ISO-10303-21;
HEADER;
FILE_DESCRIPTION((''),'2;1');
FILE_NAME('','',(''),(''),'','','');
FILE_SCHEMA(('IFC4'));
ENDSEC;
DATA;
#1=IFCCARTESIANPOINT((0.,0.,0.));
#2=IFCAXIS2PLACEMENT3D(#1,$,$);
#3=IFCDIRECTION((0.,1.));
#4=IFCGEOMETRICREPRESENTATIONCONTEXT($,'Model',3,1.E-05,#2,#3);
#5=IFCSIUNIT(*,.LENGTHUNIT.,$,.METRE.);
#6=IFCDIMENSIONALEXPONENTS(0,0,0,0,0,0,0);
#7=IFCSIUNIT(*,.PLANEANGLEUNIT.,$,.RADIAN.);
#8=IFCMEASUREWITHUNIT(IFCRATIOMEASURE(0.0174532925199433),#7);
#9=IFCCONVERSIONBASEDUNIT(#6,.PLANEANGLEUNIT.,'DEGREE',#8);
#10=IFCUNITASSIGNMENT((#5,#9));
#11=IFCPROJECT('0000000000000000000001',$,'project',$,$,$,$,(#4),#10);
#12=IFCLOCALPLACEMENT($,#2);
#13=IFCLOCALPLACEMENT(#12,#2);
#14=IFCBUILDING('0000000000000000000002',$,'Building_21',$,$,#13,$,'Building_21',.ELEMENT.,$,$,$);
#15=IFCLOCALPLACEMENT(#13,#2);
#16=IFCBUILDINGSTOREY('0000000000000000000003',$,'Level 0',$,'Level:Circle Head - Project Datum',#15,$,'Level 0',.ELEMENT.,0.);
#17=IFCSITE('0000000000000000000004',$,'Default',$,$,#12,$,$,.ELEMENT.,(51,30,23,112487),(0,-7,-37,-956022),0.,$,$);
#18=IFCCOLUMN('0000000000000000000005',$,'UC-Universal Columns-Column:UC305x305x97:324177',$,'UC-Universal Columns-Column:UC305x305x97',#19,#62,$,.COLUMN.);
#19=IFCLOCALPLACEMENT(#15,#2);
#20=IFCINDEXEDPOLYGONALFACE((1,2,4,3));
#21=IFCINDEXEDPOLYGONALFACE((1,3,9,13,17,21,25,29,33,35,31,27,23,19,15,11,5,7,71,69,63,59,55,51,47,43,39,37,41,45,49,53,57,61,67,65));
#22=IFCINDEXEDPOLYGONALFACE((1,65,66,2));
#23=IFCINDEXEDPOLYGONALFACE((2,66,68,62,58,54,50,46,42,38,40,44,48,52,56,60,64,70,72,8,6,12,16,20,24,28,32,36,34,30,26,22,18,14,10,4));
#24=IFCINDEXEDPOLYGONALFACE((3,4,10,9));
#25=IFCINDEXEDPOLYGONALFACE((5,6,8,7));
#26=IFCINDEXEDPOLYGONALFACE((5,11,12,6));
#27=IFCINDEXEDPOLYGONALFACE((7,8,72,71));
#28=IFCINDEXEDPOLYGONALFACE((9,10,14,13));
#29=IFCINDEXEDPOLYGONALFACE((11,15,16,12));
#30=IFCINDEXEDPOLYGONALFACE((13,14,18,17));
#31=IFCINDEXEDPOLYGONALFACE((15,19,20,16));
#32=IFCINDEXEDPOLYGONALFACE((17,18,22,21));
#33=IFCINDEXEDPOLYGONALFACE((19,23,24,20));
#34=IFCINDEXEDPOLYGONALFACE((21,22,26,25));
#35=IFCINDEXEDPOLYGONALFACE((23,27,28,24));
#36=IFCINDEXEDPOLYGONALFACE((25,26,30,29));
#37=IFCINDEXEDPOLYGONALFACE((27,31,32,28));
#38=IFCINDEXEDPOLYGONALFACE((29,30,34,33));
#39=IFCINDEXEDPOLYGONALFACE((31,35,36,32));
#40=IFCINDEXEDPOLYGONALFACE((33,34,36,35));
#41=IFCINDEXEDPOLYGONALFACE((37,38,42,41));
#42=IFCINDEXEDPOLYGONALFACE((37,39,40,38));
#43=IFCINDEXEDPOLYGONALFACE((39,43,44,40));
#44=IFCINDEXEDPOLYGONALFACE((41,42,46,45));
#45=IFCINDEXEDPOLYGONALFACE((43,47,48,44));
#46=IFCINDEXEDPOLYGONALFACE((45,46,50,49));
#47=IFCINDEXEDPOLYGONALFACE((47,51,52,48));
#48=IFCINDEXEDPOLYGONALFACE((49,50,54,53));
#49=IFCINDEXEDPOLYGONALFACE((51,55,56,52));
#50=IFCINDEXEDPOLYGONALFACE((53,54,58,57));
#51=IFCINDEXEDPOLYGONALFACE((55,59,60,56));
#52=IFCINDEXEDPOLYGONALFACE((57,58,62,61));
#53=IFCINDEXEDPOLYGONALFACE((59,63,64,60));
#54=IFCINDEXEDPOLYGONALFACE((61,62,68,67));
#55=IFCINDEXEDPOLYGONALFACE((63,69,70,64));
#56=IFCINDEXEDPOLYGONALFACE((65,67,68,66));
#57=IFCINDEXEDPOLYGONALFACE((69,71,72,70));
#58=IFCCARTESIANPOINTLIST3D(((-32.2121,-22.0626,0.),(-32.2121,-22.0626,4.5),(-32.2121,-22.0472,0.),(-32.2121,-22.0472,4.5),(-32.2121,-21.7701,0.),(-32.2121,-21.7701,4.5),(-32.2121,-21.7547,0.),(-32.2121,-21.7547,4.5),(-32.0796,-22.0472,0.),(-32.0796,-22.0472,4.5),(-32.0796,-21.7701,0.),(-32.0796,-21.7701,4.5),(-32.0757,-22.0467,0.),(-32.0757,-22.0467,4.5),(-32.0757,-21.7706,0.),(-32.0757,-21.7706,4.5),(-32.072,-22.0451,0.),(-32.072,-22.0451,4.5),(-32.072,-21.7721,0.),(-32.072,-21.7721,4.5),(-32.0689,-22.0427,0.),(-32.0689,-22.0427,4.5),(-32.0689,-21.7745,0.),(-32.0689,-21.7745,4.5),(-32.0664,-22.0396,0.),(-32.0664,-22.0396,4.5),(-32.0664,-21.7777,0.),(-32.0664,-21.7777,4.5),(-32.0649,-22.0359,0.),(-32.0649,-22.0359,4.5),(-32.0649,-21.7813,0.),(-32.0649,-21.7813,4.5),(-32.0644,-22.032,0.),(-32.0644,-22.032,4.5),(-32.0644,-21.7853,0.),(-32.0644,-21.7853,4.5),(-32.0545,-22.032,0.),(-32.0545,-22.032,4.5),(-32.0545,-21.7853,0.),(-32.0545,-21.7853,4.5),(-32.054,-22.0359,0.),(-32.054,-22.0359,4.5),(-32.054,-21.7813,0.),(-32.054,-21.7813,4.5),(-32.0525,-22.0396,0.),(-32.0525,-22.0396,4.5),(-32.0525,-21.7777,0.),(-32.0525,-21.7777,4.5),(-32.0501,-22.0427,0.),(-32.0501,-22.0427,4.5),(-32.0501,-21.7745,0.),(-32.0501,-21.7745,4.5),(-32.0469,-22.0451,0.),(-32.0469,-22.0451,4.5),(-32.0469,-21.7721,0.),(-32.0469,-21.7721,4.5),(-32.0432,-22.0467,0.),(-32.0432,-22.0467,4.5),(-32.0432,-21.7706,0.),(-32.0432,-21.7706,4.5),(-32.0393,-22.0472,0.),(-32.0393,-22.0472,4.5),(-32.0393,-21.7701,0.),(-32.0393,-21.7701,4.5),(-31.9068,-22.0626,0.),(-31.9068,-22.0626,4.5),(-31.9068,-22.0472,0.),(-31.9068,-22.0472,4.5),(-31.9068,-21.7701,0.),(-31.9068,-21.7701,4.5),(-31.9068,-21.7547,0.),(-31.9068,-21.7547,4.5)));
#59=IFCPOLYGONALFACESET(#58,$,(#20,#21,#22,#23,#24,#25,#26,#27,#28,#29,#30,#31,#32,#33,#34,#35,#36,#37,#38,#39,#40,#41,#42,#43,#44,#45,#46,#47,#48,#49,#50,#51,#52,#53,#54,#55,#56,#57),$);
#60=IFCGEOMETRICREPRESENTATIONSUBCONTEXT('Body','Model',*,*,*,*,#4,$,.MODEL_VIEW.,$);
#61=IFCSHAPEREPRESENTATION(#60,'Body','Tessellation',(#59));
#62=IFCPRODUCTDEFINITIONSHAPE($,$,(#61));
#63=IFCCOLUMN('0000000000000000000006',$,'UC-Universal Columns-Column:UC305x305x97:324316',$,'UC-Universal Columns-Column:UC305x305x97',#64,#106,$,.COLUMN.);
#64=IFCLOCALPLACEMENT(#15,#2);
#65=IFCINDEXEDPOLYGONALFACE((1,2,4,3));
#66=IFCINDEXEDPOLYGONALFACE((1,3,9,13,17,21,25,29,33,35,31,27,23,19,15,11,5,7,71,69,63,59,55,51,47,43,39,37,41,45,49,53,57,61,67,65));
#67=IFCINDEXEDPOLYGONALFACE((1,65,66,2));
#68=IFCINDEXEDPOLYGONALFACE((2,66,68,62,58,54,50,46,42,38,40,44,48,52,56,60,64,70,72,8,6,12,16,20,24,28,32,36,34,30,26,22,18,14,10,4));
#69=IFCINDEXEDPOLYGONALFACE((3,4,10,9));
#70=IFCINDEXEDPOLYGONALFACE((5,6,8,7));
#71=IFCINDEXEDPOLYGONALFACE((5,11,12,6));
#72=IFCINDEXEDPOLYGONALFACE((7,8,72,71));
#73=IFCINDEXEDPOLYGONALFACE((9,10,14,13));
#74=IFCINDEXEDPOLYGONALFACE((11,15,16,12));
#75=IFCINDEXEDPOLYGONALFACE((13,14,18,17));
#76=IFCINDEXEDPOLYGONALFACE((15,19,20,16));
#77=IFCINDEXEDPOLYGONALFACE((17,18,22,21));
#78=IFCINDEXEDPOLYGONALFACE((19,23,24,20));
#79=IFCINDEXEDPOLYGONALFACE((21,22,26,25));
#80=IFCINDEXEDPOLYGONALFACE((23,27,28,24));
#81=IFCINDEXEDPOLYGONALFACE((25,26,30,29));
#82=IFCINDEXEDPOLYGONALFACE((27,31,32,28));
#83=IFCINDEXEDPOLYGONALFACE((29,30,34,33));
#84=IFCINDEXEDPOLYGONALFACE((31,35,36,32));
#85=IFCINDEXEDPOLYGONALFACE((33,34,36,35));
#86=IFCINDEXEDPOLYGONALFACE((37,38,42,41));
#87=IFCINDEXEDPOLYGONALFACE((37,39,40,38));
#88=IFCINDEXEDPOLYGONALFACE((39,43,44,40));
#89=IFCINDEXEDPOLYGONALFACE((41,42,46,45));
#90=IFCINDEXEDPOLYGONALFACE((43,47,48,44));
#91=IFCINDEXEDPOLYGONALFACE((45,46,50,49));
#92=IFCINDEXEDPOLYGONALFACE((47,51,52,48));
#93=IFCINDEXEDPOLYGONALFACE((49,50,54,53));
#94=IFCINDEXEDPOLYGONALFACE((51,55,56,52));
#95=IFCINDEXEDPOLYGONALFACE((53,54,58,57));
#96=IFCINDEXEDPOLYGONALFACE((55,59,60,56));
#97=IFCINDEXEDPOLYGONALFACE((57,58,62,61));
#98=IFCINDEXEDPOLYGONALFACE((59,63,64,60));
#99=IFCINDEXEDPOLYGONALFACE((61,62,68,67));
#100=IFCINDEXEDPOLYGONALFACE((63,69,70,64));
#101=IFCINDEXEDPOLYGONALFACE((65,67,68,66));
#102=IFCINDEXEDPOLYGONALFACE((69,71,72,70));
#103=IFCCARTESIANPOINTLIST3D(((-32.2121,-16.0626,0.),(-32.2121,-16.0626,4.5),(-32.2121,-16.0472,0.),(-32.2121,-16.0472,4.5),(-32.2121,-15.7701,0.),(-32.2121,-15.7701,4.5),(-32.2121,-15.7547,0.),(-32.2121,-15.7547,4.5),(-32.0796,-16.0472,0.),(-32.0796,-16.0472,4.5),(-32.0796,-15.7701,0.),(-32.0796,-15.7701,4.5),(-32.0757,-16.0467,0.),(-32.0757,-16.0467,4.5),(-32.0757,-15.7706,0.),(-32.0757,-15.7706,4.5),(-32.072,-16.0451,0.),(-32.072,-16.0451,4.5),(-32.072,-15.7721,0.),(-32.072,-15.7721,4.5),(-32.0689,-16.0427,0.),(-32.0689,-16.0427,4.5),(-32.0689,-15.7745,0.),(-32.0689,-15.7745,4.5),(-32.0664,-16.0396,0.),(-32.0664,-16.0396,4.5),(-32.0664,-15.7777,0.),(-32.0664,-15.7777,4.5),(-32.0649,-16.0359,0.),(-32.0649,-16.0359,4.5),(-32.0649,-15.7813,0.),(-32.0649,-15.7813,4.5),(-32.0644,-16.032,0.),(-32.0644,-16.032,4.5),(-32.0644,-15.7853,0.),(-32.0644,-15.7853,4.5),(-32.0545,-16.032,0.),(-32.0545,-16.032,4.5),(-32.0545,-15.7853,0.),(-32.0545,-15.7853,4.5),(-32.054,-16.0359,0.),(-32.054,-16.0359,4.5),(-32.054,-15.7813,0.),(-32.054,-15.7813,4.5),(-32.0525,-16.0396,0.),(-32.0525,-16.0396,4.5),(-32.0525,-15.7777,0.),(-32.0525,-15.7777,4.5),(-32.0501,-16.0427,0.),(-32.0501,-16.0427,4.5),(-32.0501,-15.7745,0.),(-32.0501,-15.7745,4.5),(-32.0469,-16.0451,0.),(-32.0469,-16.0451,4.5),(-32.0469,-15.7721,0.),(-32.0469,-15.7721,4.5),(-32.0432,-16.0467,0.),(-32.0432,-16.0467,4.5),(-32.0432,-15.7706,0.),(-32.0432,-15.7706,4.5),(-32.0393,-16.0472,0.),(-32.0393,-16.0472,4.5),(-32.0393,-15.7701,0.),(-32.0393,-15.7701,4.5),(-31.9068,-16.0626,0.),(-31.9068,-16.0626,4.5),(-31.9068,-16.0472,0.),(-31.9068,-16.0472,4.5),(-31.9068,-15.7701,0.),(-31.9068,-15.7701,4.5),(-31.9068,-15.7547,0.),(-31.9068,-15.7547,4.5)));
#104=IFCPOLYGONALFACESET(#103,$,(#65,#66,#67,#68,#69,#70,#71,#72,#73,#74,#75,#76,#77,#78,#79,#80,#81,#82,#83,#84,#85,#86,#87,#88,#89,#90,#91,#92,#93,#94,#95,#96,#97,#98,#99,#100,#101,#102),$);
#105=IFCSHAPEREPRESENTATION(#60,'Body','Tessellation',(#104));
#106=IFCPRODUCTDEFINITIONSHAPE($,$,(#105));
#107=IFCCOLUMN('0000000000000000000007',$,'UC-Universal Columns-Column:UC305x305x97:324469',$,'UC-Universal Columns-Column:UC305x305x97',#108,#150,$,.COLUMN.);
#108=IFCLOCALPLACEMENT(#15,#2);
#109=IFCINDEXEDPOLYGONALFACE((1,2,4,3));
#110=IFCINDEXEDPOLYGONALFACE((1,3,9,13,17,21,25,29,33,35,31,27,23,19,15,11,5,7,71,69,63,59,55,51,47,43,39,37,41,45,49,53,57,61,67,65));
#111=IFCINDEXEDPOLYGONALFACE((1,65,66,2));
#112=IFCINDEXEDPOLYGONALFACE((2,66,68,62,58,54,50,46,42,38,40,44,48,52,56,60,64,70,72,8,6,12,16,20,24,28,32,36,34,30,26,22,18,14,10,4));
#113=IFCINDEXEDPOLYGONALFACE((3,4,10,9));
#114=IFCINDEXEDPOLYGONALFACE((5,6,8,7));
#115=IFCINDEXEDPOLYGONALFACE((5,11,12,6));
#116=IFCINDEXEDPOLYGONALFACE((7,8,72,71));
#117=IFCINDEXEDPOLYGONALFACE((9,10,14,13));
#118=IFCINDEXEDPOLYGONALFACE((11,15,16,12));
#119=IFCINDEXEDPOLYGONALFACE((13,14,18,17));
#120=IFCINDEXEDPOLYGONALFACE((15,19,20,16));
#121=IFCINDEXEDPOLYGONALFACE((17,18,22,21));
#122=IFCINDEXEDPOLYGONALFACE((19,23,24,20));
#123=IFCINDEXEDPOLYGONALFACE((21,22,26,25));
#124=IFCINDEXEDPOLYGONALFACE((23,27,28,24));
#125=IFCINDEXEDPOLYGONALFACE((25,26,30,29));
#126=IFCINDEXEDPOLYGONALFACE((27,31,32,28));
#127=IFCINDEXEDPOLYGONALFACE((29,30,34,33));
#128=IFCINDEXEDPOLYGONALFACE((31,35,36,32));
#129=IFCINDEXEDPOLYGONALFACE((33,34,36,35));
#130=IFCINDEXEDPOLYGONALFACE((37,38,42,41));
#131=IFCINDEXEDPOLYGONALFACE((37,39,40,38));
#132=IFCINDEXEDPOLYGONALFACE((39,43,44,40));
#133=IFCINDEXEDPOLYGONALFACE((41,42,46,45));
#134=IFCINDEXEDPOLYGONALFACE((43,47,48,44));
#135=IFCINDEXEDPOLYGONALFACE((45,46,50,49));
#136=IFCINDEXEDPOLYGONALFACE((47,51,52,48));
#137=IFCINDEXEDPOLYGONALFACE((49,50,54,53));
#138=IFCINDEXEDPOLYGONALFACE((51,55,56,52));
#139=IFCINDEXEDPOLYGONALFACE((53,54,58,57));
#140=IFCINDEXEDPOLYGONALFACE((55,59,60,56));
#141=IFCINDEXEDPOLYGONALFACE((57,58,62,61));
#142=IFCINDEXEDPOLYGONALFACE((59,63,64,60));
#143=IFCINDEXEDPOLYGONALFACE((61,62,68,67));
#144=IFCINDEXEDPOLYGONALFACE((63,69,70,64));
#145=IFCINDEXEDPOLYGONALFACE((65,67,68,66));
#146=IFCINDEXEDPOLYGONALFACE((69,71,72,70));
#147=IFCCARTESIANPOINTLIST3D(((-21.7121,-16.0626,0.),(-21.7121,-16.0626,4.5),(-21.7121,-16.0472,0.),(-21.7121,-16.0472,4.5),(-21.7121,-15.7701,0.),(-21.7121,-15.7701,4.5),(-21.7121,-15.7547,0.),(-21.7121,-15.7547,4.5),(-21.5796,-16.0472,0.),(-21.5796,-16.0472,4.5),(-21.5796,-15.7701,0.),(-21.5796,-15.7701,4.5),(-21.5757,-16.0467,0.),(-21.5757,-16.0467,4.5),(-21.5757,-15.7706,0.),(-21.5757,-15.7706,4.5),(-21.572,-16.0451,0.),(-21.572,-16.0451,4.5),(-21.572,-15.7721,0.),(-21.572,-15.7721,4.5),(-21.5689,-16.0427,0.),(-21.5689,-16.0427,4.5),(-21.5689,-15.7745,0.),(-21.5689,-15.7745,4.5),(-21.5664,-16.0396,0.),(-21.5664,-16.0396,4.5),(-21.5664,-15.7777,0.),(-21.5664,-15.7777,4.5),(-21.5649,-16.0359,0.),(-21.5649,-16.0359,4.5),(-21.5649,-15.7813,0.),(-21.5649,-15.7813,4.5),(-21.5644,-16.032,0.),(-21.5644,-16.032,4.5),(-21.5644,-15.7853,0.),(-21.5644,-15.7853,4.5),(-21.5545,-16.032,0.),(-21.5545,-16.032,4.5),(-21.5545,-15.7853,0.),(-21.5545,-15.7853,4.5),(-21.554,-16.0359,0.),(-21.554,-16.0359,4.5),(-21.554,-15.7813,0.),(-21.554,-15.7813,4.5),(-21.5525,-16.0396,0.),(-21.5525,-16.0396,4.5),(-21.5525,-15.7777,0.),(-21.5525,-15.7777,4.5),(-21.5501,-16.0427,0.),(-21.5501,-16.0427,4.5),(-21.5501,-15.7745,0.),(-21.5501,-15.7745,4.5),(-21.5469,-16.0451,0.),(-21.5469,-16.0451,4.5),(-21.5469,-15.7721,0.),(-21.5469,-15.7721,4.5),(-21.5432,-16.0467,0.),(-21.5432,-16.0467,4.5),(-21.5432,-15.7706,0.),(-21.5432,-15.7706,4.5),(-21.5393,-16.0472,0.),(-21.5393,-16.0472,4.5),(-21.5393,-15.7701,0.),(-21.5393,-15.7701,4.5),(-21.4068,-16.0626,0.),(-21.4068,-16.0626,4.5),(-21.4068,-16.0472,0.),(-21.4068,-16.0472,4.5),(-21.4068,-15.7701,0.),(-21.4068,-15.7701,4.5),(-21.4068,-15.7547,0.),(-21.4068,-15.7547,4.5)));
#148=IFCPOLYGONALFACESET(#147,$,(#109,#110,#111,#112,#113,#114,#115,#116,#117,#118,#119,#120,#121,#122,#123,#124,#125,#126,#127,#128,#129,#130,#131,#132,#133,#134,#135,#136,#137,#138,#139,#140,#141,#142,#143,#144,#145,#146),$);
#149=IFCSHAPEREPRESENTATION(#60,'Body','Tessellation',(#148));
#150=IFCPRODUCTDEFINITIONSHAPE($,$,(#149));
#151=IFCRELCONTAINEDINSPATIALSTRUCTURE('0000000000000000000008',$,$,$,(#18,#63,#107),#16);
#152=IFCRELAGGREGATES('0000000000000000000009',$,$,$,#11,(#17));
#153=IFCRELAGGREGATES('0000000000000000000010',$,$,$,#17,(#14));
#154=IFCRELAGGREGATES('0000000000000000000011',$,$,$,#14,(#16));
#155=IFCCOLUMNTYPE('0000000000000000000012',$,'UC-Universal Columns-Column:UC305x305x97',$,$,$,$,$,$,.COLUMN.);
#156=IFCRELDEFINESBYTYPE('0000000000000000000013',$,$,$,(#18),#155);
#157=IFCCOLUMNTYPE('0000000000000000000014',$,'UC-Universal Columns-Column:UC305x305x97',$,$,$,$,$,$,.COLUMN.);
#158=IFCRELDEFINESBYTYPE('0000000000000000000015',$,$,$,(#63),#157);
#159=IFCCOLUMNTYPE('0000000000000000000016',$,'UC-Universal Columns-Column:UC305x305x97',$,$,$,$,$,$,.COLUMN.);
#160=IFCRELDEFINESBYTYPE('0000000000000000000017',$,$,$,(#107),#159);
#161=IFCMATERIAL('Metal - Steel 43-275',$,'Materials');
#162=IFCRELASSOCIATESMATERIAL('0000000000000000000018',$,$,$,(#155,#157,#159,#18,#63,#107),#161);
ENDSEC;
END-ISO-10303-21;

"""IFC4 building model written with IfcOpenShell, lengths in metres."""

from ifc_helpers import new_model, entity, si_unit, converted_unit, direction, frame, frame_2d, origin, place, context, subcontext, project, spatial, polyline, circle_curve, parameter, trimmed, segment, composite_curve, i_section, outline, extrude, source, transform, mapped, material, material_profile, profile_set, profile_usage, type_object, type_shapes, element, save


model = new_model("IFC4")

# Units and contexts
model_context = context("Model", 3, precision=1e-05, world=origin(), true_north=direction((0.0, 1.0)))
body_context = subcontext(model_context, "Body", "Model", "MODEL_VIEW")
ifc_project = project(units=[si_unit("LENGTHUNIT", "METRE"), converted_unit("PLANEANGLEUNIT", "DEGREE", entity("IfcRatioMeasure", 0.0174532925199433), si_unit("PLANEANGLEUNIT", "RADIAN"), dimensions=[0, 0, 0, 0, 0, 0, 0])], contexts=[model_context])

# Site, building, storey
site_placement = place(None, origin())
site = spatial("IfcSite", under=ifc_project, at=site_placement, Name="Default", CompositionType="ELEMENT", RefLatitude=(51, 30, 23, 112487), RefLongitude=(0, -7, -37, -956022), RefElevation=0.0)
building_placement = place(site_placement, origin())
building = spatial("IfcBuilding", under=site, at=building_placement, Name="Building_21", LongName="Building_21", CompositionType="ELEMENT")
storey_placement = place(building_placement, origin())
storey = spatial("IfcBuildingStorey", under=building, at=storey_placement, Name="Level 0", ObjectType="Level:Circle Head - Project Datum", LongName="Level 0", CompositionType="ELEMENT", Elevation=0.0)

# Columns
ifc_material_1 = material(Name="Metal - Steel 43-275", Category="Materials")
ifc_material_profile_1 = material_profile(ifc_material_1, outline(composite_curve([segment(polyline([(-0.1527, 0.154, 0.0), (0.1527, 0.154, 0.0)]), True, "CONTINUOUS"), segment(polyline([(0.1527, 0.154, 0.0), (0.1527, 0.1386, 0.0)]), True, "CONTINUOUS"), segment(polyline([(0.1527, 0.1386, 0.0), (0.0201, 0.1386, 0.0)]), True, "CONTINUOUS"), segment(trimmed(circle_curve(frame((0.0201, 0.1234, 0.0)), 0.0152), [parameter(90.0)], [parameter(180.0)], True, "PARAMETER"), True, "CONTINUOUS"), segment(polyline([(0.0049, 0.1234, 0.0), (0.0049, -0.1234, 0.0)]), True, "CONTINUOUS"), segment(trimmed(circle_curve(frame((0.0201, -0.1234, 0.0)), 0.0152), [parameter(180.0)], [parameter(270.0)], True, "PARAMETER"), True, "CONTINUOUS"), segment(polyline([(0.0201, -0.1386, 0.0), (0.1527, -0.1386, 0.0)]), True, "CONTINUOUS"), segment(polyline([(0.1527, -0.1386, 0.0), (0.1527, -0.154, 0.0)]), True, "CONTINUOUS"), segment(polyline([(0.1527, -0.154, 0.0), (-0.1527, -0.154, 0.0)]), True, "CONTINUOUS"), segment(polyline([(-0.1527, -0.154, 0.0), (-0.1527, -0.1386, 0.0)]), True, "CONTINUOUS"), segment(polyline([(-0.1527, -0.1386, 0.0), (-0.0201, -0.1386, 0.0)]), True, "CONTINUOUS"), segment(trimmed(circle_curve(frame((-0.0201, -0.1234, 0.0)), 0.0152), [parameter(270.0)], [parameter(0.0)], True, "PARAMETER"), True, "CONTINUOUS"), segment(polyline([(-0.0049, -0.1234, 0.0), (-0.005, 0.1234, 0.0)]), True, "CONTINUOUS"), segment(trimmed(circle_curve(frame((-0.0201, 0.1234, 0.0)), 0.0152), [parameter(0.0)], [parameter(90.0)], True, "PARAMETER"), True, "CONTINUOUS"), segment(polyline([(-0.0201, 0.1386, 0.0), (-0.1527, 0.1386, 0.0)]), True, "CONTINUOUS"), segment(polyline([(-0.1527, 0.1386, 0.0), (-0.1527, 0.154, 0.0)]), True, "CONTINUOUS")], self_intersect=False), kind="CURVE"), Name="UC305x305x97")
ifc_material_profile_2 = material_profile(ifc_material_1, outline(composite_curve([segment(polyline([(0.1527, 0.154, 0.0), (0.1527, 0.1386, 0.0)]), True, "CONTINUOUS"), segment(polyline([(0.1527, 0.1386, 0.0), (0.0049, 0.1386, 0.0)]), True, "CONTINUOUS"), segment(polyline([(0.0049, 0.1386, 0.0), (0.0049, -0.1386, 0.0)]), True, "CONTINUOUS"), segment(polyline([(0.0049, -0.1386, 0.0), (0.1527, -0.1386, 0.0)]), True, "CONTINUOUS"), segment(polyline([(0.1527, -0.1386, 0.0), (0.1527, -0.154, 0.0)]), True, "CONTINUOUS"), segment(polyline([(0.1527, -0.154, 0.0), (-0.1527, -0.154, 0.0)]), True, "CONTINUOUS"), segment(polyline([(-0.1527, -0.154, 0.0), (-0.1527, -0.1386, 0.0)]), True, "CONTINUOUS"), segment(polyline([(-0.1527, -0.1386, 0.0), (-0.005, -0.1386, 0.0)]), True, "CONTINUOUS"), segment(polyline([(-0.005, -0.1386, 0.0), (-0.005, 0.1386, 0.0)]), True, "CONTINUOUS"), segment(polyline([(-0.005, 0.1386, 0.0), (-0.1527, 0.1386, 0.0)]), True, "CONTINUOUS"), segment(polyline([(-0.1527, 0.1386, 0.0), (-0.1527, 0.154, 0.0)]), True, "CONTINUOUS"), segment(polyline([(-0.1527, 0.154, 0.0), (0.1527, 0.154, 0.0)]), True, "CONTINUOUS")], self_intersect=False), kind="CURVE"), Name="UC305x305x97")
ifc_profile_set = profile_set([ifc_material_profile_1, ifc_material_profile_2], Name="UC305x305x97")
ifc_profile_usage_1 = profile_usage(ifc_profile_set)
column_type_1 = type_object("IfcColumnType", Name="UC-Universal Columns-Column:UC305x305x97", PredefinedType="COLUMN", material=ifc_profile_set)
shared_shape_1 = source(origin(), body_context, "Body", "SweptSolid", [
    extrude(i_section(OverallWidth=0.3053, OverallDepth=0.3079, WebThickness=0.0099, FlangeThickness=0.0154, FilletRadius=0.0152, at=frame_2d((0.0, 0.0), x_axis=(0.0, 1.0))), frame((-32.0595, -21.9086, 0.0), z_axis=(0.0, 0.0, 1.0), x_axis=(0.0, -1.0, 0.0)), (0.0, 0.0, 1.0), 4.5),
])
type_shapes(column_type_1, [shared_shape_1])
column_1_placement = place(storey_placement, origin())
element("IfcColumn", 1, at=column_1_placement, inside=storey, type_object=column_type_1, material=ifc_profile_usage_1, Name="UC-Universal Columns-Column:UC305x305x97:324177", ObjectType="UC-Universal Columns-Column:UC305x305x97", PredefinedType="COLUMN", context=body_context, shape_type="MappedRepresentation", body=[
    mapped(shared_shape_1, transform((0.0, 0.0, 0.0), scale=1.0)),
])
ifc_profile_usage_2 = profile_usage(ifc_profile_set)
column_type_2 = type_object("IfcColumnType", Name="UC-Universal Columns-Column:UC305x305x97", PredefinedType="COLUMN", material=ifc_profile_set)
shared_shape_2 = source(origin(), body_context, "Body", "SweptSolid", [
    extrude(i_section(OverallWidth=0.3053, OverallDepth=0.3079, WebThickness=0.0099, FlangeThickness=0.0154, FilletRadius=0.0152, at=frame_2d((0.0, 0.0), x_axis=(0.0, 1.0))), frame((-32.0595, -15.9086, 0.0), z_axis=(0.0, 0.0, 1.0), x_axis=(0.0, -1.0, 0.0)), (0.0, 0.0, 1.0), 4.5),
])
type_shapes(column_type_2, [shared_shape_2])
column_2_placement = place(storey_placement, origin())
element("IfcColumn", 2, at=column_2_placement, inside=storey, type_object=column_type_2, material=ifc_profile_usage_2, Name="UC-Universal Columns-Column:UC305x305x97:324316", ObjectType="UC-Universal Columns-Column:UC305x305x97", PredefinedType="COLUMN", context=body_context, shape_type="MappedRepresentation", body=[
    mapped(shared_shape_2, transform((0.0, 0.0, 0.0), scale=1.0)),
])
ifc_profile_usage_3 = profile_usage(ifc_profile_set)
column_type_3 = type_object("IfcColumnType", Name="UC-Universal Columns-Column:UC305x305x97", PredefinedType="COLUMN", material=ifc_profile_set)
shared_shape_3 = source(origin(), body_context, "Body", "SweptSolid", [
    extrude(i_section(OverallWidth=0.3053, OverallDepth=0.3079, WebThickness=0.0099, FlangeThickness=0.0154, FilletRadius=0.0152, at=frame_2d((0.0, 0.0), x_axis=(0.0, 1.0))), frame((-21.5595, -15.9086, 0.0), z_axis=(0.0, 0.0, 1.0), x_axis=(0.0, -1.0, 0.0)), (0.0, 0.0, 1.0), 4.5),
])
type_shapes(column_type_3, [shared_shape_3])
column_3_placement = place(storey_placement, origin())
element("IfcColumn", 3, at=column_3_placement, inside=storey, type_object=column_type_3, material=ifc_profile_usage_3, Name="UC-Universal Columns-Column:UC305x305x97:324469", ObjectType="UC-Universal Columns-Column:UC305x305x97", PredefinedType="COLUMN", context=body_context, shape_type="MappedRepresentation", body=[
    mapped(shared_shape_3, transform((0.0, 0.0, 0.0), scale=1.0)),
])

save(model, "model.ifc")
